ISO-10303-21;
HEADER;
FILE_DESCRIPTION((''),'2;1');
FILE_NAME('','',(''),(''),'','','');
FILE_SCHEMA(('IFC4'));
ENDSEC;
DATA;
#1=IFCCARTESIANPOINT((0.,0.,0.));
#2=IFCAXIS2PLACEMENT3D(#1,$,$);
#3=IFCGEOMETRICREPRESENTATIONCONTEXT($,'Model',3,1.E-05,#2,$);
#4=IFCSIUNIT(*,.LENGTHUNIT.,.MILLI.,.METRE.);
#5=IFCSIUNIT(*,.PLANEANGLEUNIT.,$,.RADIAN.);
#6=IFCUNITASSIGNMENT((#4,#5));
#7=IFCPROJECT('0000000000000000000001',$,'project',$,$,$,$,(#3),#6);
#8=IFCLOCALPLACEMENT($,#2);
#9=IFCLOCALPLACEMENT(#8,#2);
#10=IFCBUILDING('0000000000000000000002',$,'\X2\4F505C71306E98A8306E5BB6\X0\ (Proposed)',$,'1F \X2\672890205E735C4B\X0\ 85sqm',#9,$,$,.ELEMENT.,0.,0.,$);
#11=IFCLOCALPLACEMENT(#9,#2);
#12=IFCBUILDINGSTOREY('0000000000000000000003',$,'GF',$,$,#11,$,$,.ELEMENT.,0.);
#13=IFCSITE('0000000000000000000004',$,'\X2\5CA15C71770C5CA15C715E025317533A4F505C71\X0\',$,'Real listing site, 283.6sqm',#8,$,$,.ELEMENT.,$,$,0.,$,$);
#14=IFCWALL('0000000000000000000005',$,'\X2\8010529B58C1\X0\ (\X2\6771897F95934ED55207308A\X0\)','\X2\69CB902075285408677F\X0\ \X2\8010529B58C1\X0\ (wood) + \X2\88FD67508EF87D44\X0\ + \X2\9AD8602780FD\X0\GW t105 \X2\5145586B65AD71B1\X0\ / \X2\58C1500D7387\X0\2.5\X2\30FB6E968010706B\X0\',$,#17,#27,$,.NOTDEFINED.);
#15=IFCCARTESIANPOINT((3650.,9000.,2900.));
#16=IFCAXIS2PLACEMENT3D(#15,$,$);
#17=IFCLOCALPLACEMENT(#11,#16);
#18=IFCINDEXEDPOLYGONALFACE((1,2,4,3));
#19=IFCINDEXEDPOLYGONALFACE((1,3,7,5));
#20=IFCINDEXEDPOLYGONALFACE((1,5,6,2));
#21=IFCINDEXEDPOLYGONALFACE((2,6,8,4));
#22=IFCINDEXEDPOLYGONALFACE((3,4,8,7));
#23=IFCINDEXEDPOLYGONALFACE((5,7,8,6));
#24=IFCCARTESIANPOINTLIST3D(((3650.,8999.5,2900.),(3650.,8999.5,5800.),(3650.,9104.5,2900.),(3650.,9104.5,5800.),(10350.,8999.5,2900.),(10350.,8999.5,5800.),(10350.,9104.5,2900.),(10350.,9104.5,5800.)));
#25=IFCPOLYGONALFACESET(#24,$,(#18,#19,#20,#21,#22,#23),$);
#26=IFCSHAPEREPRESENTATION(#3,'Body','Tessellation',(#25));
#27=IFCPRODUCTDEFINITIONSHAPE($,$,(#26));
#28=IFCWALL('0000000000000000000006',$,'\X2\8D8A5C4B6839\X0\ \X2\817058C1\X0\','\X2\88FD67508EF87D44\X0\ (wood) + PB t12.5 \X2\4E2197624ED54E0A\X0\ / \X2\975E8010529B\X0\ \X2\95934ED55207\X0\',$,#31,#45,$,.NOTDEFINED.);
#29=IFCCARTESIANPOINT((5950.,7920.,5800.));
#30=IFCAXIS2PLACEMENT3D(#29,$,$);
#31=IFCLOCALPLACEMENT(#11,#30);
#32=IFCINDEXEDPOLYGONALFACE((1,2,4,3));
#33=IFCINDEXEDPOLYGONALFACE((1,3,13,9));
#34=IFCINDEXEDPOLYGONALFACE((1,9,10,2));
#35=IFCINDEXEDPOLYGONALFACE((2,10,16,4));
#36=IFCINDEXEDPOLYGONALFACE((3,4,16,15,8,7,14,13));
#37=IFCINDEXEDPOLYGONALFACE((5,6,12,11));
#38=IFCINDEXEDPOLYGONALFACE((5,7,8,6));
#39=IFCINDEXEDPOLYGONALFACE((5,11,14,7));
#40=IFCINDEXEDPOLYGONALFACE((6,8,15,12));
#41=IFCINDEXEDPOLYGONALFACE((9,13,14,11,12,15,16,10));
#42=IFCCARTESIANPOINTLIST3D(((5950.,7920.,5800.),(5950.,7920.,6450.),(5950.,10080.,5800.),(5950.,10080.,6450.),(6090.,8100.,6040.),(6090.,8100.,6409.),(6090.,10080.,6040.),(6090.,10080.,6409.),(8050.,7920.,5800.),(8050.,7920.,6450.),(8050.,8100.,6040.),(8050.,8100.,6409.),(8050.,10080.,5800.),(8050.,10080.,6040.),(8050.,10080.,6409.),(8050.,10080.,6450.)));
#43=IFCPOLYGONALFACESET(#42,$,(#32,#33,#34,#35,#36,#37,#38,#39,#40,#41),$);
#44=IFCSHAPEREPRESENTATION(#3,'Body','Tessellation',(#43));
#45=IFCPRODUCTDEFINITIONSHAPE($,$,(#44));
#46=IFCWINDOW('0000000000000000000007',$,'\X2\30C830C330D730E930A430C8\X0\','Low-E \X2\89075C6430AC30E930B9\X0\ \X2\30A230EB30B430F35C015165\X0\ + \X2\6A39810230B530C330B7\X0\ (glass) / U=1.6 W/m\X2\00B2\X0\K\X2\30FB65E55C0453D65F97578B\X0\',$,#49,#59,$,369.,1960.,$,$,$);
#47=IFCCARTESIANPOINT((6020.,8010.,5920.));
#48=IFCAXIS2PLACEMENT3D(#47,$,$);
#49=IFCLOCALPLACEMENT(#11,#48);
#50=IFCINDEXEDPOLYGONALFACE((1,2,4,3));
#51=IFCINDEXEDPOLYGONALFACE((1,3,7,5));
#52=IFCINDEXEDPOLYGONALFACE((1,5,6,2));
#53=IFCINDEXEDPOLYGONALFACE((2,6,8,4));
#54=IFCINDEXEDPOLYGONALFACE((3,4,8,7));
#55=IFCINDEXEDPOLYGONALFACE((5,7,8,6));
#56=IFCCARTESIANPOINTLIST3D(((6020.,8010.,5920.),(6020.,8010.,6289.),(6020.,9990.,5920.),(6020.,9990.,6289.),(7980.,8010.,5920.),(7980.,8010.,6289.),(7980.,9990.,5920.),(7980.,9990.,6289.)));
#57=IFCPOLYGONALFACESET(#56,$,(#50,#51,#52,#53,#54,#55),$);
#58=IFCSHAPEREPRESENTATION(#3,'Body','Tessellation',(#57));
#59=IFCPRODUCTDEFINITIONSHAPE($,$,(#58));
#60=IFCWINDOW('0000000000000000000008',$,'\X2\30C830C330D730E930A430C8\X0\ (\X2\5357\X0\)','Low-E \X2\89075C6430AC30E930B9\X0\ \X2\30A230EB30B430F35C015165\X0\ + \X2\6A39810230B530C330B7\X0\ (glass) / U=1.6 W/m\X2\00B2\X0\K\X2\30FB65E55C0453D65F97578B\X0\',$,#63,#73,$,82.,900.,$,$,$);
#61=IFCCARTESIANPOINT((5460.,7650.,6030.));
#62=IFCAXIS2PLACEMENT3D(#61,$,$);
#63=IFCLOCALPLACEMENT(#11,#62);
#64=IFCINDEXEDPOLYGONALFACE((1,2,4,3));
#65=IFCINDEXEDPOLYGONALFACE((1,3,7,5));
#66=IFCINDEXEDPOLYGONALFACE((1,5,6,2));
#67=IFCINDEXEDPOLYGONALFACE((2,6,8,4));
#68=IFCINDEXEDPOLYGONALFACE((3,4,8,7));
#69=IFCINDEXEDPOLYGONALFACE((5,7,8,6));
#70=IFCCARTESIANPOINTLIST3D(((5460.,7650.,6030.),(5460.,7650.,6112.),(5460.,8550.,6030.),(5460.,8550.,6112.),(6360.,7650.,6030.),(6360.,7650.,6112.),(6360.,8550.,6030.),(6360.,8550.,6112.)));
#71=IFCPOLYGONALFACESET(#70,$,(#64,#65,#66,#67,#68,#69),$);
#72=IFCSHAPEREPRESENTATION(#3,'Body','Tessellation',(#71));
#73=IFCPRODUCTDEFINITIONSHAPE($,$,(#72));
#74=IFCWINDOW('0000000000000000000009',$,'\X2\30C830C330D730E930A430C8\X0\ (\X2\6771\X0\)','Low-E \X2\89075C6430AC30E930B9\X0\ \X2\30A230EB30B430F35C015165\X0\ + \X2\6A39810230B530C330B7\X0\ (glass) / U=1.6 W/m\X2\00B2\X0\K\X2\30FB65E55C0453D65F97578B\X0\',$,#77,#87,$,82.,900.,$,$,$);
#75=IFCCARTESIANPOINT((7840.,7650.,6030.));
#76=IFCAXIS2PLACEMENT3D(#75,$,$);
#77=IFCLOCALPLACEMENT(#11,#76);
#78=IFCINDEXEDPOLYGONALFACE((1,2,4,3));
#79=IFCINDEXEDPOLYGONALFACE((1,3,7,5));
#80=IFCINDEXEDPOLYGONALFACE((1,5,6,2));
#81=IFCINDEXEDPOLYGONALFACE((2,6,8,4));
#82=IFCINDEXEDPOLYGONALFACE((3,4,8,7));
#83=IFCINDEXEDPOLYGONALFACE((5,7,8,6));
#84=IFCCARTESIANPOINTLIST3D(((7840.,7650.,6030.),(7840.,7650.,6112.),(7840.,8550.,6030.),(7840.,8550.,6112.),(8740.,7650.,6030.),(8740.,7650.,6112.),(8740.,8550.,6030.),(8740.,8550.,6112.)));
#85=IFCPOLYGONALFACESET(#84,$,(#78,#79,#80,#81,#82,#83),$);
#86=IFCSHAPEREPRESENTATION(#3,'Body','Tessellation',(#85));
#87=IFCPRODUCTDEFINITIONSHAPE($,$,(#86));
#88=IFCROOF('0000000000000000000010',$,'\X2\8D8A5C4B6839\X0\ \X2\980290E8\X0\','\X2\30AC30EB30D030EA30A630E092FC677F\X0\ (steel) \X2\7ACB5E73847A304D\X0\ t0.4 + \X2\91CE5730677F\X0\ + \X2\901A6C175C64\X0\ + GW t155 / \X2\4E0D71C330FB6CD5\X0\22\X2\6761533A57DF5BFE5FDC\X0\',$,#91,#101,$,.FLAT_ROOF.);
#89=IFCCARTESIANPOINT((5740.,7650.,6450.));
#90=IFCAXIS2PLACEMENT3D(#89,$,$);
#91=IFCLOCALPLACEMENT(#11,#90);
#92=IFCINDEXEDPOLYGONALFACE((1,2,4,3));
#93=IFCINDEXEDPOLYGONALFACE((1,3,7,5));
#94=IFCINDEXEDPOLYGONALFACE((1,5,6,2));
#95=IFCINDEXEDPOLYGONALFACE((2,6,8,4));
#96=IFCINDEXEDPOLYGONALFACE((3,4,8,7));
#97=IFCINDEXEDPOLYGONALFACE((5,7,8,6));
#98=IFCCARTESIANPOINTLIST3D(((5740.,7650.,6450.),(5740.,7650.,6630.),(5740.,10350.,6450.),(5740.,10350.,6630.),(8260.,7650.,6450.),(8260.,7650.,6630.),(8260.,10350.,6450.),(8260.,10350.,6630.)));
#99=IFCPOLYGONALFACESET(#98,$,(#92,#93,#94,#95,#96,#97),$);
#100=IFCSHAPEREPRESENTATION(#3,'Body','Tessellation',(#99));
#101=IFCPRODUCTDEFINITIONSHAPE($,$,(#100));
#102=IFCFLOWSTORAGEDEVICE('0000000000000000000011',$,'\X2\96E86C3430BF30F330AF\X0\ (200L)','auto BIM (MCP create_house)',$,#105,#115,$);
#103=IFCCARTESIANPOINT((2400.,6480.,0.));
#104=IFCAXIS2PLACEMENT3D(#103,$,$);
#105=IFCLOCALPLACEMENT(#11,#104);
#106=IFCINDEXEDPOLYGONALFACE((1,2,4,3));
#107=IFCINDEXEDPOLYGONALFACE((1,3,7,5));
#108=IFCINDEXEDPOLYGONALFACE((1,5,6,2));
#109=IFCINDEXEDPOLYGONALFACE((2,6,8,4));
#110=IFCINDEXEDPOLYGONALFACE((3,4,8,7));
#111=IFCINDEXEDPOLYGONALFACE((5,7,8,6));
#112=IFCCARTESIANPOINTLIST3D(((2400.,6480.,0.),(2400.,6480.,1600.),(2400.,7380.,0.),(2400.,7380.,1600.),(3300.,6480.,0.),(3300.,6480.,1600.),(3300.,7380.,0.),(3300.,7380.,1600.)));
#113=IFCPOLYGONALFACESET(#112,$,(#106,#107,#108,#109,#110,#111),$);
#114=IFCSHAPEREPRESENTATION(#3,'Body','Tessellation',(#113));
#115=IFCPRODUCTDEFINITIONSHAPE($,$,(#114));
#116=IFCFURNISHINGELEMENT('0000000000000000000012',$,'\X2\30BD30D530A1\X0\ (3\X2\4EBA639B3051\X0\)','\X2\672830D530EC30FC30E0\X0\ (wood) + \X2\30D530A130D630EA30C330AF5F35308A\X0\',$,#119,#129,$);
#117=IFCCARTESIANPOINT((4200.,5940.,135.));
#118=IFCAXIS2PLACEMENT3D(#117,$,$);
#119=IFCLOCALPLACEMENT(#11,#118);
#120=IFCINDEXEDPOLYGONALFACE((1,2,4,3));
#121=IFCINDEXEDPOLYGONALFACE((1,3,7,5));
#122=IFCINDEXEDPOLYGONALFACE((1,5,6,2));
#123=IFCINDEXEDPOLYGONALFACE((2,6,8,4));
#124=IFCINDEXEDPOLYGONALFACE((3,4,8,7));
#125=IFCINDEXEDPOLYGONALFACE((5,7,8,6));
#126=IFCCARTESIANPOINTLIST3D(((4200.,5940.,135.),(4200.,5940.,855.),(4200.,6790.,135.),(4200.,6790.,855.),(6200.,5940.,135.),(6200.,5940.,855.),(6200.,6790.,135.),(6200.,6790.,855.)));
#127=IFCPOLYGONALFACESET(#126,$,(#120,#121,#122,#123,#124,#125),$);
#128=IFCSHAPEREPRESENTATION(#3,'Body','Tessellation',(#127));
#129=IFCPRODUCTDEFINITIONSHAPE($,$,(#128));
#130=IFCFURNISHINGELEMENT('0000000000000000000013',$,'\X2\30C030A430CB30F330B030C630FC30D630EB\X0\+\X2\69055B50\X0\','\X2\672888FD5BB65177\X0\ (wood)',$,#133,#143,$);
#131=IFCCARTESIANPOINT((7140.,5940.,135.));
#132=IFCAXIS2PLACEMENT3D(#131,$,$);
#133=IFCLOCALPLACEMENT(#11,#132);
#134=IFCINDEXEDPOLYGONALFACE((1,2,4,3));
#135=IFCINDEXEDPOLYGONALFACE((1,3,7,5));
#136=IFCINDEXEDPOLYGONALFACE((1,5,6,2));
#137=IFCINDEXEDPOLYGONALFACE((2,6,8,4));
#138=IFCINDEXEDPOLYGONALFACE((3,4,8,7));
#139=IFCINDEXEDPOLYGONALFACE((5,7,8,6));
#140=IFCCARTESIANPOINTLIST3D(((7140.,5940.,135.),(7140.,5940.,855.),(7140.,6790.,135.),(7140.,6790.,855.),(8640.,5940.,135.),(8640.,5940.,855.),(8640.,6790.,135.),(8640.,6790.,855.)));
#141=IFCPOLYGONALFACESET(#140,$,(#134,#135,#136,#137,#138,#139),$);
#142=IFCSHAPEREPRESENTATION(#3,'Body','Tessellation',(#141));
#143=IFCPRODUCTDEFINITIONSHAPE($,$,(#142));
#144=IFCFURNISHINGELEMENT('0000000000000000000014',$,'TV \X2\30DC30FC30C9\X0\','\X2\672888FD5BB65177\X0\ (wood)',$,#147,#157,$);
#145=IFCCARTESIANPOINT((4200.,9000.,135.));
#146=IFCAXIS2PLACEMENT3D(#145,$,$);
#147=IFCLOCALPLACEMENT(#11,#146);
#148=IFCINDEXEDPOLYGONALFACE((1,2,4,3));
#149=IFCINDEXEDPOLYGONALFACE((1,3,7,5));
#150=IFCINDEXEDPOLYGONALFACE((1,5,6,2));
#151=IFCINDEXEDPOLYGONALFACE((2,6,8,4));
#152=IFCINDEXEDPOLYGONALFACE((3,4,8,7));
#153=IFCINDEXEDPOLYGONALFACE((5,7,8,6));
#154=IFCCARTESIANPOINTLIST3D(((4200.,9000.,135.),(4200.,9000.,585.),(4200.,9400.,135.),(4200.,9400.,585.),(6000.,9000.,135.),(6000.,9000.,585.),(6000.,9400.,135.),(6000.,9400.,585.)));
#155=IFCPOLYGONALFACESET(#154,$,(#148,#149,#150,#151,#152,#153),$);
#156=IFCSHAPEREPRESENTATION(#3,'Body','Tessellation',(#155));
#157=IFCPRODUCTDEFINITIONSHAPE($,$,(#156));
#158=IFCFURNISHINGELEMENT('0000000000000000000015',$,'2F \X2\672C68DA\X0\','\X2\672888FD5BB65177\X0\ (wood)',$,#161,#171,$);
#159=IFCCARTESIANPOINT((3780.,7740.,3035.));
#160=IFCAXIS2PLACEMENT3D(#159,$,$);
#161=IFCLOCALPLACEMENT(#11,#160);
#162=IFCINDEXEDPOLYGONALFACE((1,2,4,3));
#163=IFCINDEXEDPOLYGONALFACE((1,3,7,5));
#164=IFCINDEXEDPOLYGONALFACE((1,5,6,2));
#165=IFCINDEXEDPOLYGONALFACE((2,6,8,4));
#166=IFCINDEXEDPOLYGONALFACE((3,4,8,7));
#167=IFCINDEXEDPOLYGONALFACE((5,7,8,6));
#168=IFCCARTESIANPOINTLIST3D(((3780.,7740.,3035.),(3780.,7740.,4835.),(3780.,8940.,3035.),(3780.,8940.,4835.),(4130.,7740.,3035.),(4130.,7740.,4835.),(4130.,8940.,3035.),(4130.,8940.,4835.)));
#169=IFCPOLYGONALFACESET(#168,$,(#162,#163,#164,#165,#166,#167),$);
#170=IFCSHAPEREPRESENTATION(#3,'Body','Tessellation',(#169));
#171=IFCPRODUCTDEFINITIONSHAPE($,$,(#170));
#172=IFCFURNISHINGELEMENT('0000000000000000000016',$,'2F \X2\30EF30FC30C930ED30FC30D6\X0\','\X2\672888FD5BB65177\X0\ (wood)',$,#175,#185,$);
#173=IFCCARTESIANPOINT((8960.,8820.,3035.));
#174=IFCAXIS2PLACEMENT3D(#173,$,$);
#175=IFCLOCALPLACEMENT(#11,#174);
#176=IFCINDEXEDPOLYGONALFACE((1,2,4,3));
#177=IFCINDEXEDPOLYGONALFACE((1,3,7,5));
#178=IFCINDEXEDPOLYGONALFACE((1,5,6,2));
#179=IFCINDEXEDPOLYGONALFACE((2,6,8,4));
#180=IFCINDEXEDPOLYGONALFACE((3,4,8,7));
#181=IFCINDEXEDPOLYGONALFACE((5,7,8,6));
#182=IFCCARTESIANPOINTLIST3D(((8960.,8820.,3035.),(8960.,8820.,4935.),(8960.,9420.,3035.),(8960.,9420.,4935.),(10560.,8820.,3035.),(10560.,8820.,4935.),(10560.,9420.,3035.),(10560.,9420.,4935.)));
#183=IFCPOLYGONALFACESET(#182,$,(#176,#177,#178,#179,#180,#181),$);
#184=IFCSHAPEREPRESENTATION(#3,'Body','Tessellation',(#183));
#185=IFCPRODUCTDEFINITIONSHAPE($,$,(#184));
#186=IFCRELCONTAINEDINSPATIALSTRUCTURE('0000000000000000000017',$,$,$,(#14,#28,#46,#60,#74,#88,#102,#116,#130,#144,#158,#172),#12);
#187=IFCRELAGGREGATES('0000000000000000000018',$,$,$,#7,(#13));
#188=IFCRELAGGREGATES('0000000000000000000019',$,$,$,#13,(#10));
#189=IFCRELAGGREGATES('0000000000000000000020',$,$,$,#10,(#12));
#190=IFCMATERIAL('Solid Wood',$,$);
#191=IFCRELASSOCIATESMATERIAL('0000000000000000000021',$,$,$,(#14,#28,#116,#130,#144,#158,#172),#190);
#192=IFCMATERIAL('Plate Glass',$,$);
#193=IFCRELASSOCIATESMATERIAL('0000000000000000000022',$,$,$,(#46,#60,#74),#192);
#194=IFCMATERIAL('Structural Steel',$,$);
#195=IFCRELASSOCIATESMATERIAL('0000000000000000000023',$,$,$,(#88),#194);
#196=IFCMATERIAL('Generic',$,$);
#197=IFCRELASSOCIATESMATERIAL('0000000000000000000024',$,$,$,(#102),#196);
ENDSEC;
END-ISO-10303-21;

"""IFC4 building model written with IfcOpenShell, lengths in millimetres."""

from ifc_helpers import new_model, si_unit, frame, frame_2d, origin, place, context, project, spatial, rectangle, extrude, material, element, fill, save


model = new_model("IFC4")

# Units and contexts
model_context = context("Model", 3, precision=1e-05, world=origin())
ifc_project = project(units=[si_unit("LENGTHUNIT", "METRE", prefix="MILLI"), si_unit("PLANEANGLEUNIT", "RADIAN")], contexts=[model_context])

# Site, building, storey
site_placement = place(None, origin())
site = spatial("IfcSite", under=ifc_project, at=site_placement, Name="岡山県岡山市北区佐山", ObjectType="Real listing site, 283.6sqm", CompositionType="ELEMENT", RefElevation=0.0)
building_placement = place(site_placement, origin())
building = spatial("IfcBuilding", under=site, at=building_placement, Name="佐山の風の家 (Proposed)", ObjectType="1F 木造平屋 85sqm", CompositionType="ELEMENT", ElevationOfRefHeight=0.0, ElevationOfTerrain=0.0)
storey_placement = place(building_placement, origin())
storey = spatial("IfcBuildingStorey", under=building, at=storey_placement, Name="GF", CompositionType="ELEMENT", Elevation=0.0)

# Wall
ifc_material_1 = material(Name="Solid Wood")
wall_1_placement = place(storey_placement, frame((3650.0, 9000.0, 2900.0)))
element("IfcWall", 1, at=wall_1_placement, inside=storey, material=ifc_material_1, Name="耐力壁 (東西間仕切り)", Description="構造用合板 耐力壁 (wood) + 製材軸組 + 高性能GW t105 充填断熱 / 壁倍率2.5・準耐火", PredefinedType="NOTDEFINED", context=model_context, shape_type="SweptSolid", body=[
    extrude(rectangle(XDim=6700.0, YDim=105.0, at=frame_2d((3350.0, 52.0))), frame((3650.0, 9000.0, 2900.0)), (0.0, 0.0, 1.0), 2900.0),
])

# Wall, openings, windows
wall_2_placement = place(storey_placement, frame((5950.0, 7920.0, 5800.0)))
wall_2 = element("IfcWall", 2, at=wall_2_placement, inside=storey, material=ifc_material_1, Name="越屋根 腰壁", Description="製材軸組 (wood) + PB t12.5 両面仕上 / 非耐力 間仕切", PredefinedType="NOTDEFINED", context=model_context, shape_type="SweptSolid", body=[
    extrude(rectangle(XDim=2100.0, YDim=2160.0, at=frame_2d((1050.0, 1080.0))), frame((5950.0, 7920.0, 5800.0)), (0.0, 0.0, 1.0), 650.0),
])
opening_1_placement = place(storey_placement, frame((6020.0, 8010.0, 5920.0)))
opening_1 = element("IfcOpeningElement", 3, at=opening_1_placement, cuts=wall_2, PredefinedType="NOTDEFINED", context=model_context, shape_type="SweptSolid", body=[
    extrude(rectangle(XDim=1960.0, YDim=1980.0, at=frame_2d((980.0, 990.0))), frame((6020.0, 8010.0, 5920.0)), (0.0, 0.0, 1.0), 369.0),
])
opening_2_placement = place(storey_placement, frame((5460.0, 7650.0, 6030.0)))
opening_2 = element("IfcOpeningElement", 4, at=opening_2_placement, cuts=wall_2, PredefinedType="NOTDEFINED", context=model_context, shape_type="SweptSolid", body=[
    extrude(rectangle(XDim=900.0, YDim=900.0, at=frame_2d((450.0, 450.0))), frame((5460.0, 7650.0, 6030.0)), (0.0, 0.0, 1.0), 82.0),
])
opening_3_placement = place(storey_placement, frame((7840.0, 7650.0, 6030.0)))
opening_3 = element("IfcOpeningElement", 5, at=opening_3_placement, cuts=wall_2, PredefinedType="NOTDEFINED", context=model_context, shape_type="SweptSolid", body=[
    extrude(rectangle(XDim=900.0, YDim=900.0, at=frame_2d((450.0, 450.0))), frame((7840.0, 7650.0, 6030.0)), (0.0, 0.0, 1.0), 82.0),
])
ifc_material_2 = material(Name="Plate Glass")
window_1_placement = place(storey_placement, frame((6020.0, 8010.0, 5920.0)))
window_1 = element("IfcWindow", 6, at=window_1_placement, inside=storey, material=ifc_material_2, Name="トップライト", Description="Low-E 複層ガラス アルゴン封入 + 樹脂サッシ (glass) / U=1.6 W/m²K・日射取得型", OverallHeight=369.0, OverallWidth=1960.0, context=model_context, shape_type="SweptSolid", body=[
    extrude(rectangle(XDim=1960.0, YDim=1980.0, at=frame_2d((980.0, 990.0))), frame((6020.0, 8010.0, 5920.0)), (0.0, 0.0, 1.0), 369.0),
])
fill(opening_1, window_1)
window_2_placement = place(storey_placement, frame((5460.0, 7650.0, 6030.0)))
window_2 = element("IfcWindow", 7, at=window_2_placement, inside=storey, material=ifc_material_2, Name="トップライト (南)", Description="Low-E 複層ガラス アルゴン封入 + 樹脂サッシ (glass) / U=1.6 W/m²K・日射取得型", OverallHeight=82.0, OverallWidth=900.0, context=model_context, shape_type="SweptSolid", body=[
    extrude(rectangle(XDim=900.0, YDim=900.0, at=frame_2d((450.0, 450.0))), frame((5460.0, 7650.0, 6030.0)), (0.0, 0.0, 1.0), 82.0),
])
fill(opening_2, window_2)
window_3_placement = place(storey_placement, frame((7840.0, 7650.0, 6030.0)))
window_3 = element("IfcWindow", 8, at=window_3_placement, inside=storey, material=ifc_material_2, Name="トップライト (東)", Description="Low-E 複層ガラス アルゴン封入 + 樹脂サッシ (glass) / U=1.6 W/m²K・日射取得型", OverallHeight=82.0, OverallWidth=900.0, context=model_context, shape_type="SweptSolid", body=[
    extrude(rectangle(XDim=900.0, YDim=900.0, at=frame_2d((450.0, 450.0))), frame((7840.0, 7650.0, 6030.0)), (0.0, 0.0, 1.0), 82.0),
])
fill(opening_3, window_3)

# Roof
ifc_material_3 = material(Name="Structural Steel")
roof_placement = place(storey_placement, frame((5740.0, 7650.0, 6450.0)))
element("IfcRoof", 9, at=roof_placement, inside=storey, material=ifc_material_3, Name="越屋根 頂部", Description="ガルバリウム鋼板 (steel) 立平葺き t0.4 + 野地板 + 通気層 + GW t155 / 不燃・法22条区域対応", PredefinedType="FLAT_ROOF", context=model_context, shape_type="SweptSolid", body=[
    extrude(rectangle(XDim=2520.0, YDim=2700.0, at=frame_2d((1260.0, 1350.0))), frame((5740.0, 7650.0, 6450.0)), (0.0, 0.0, 1.0), 180.0),
])

# Flow storage device
ifc_material_4 = material(Name="Generic")
flow_storage_device_placement = place(storey_placement, frame((2400.0, 6480.0, 0.0)))
element("IfcFlowStorageDevice", 10, at=flow_storage_device_placement, inside=storey, material=ifc_material_4, Name="雨水タンク (200L)", Description="auto BIM (MCP create_house)", context=model_context, shape_type="SweptSolid", body=[
    extrude(rectangle(XDim=900.0, YDim=900.0, at=frame_2d((450.0, 450.0))), frame((2400.0, 6480.0, 0.0)), (0.0, 0.0, 1.0), 1600.0),
])

# Furnishing elements
furnishing_1_placement = place(storey_placement, frame((4200.0, 5940.0, 135.0)))
element("IfcFurnishingElement", 11, at=furnishing_1_placement, inside=storey, material=ifc_material_1, Name="ソファ (3人掛け)", Description="木フレーム (wood) + ファブリック張り", context=model_context, shape_type="SweptSolid", body=[
    extrude(rectangle(XDim=2000.0, YDim=850.0, at=frame_2d((1000.0, 425.0))), frame((4200.0, 5940.0, 135.0)), (0.0, 0.0, 1.0), 720.0),
])
furnishing_2_placement = place(storey_placement, frame((7140.0, 5940.0, 135.0)))
element("IfcFurnishingElement", 12, at=furnishing_2_placement, inside=storey, material=ifc_material_1, Name="ダイニングテーブル+椅子", Description="木製家具 (wood)", context=model_context, shape_type="SweptSolid", body=[
    extrude(rectangle(XDim=1500.0, YDim=850.0, at=frame_2d((750.0, 425.0))), frame((7140.0, 5940.0, 135.0)), (0.0, 0.0, 1.0), 720.0),
])
furnishing_3_placement = place(storey_placement, frame((4200.0, 9000.0, 135.0)))
element("IfcFurnishingElement", 13, at=furnishing_3_placement, inside=storey, material=ifc_material_1, Name="TV ボード", Description="木製家具 (wood)", context=model_context, shape_type="SweptSolid", body=[
    extrude(rectangle(XDim=1800.0, YDim=400.0, at=frame_2d((900.0, 200.0))), frame((4200.0, 9000.0, 135.0)), (0.0, 0.0, 1.0), 450.0),
])
furnishing_4_placement = place(storey_placement, frame((3780.0, 7740.0, 3035.0)))
element("IfcFurnishingElement", 14, at=furnishing_4_placement, inside=storey, material=ifc_material_1, Name="2F 本棚", Description="木製家具 (wood)", context=model_context, shape_type="SweptSolid", body=[
    extrude(rectangle(XDim=350.0, YDim=1200.0, at=frame_2d((175.0, 600.0))), frame((3780.0, 7740.0, 3035.0)), (0.0, 0.0, 1.0), 1800.0),
])
furnishing_5_placement = place(storey_placement, frame((8960.0, 8820.0, 3035.0)))
element("IfcFurnishingElement", 15, at=furnishing_5_placement, inside=storey, material=ifc_material_1, Name="2F ワードローブ", Description="木製家具 (wood)", context=model_context, shape_type="SweptSolid", body=[
    extrude(rectangle(XDim=1600.0, YDim=600.0, at=frame_2d((800.0, 300.0))), frame((8960.0, 8820.0, 3035.0)), (0.0, 0.0, 1.0), 1900.0),
])

save(model, "model.ifc")
